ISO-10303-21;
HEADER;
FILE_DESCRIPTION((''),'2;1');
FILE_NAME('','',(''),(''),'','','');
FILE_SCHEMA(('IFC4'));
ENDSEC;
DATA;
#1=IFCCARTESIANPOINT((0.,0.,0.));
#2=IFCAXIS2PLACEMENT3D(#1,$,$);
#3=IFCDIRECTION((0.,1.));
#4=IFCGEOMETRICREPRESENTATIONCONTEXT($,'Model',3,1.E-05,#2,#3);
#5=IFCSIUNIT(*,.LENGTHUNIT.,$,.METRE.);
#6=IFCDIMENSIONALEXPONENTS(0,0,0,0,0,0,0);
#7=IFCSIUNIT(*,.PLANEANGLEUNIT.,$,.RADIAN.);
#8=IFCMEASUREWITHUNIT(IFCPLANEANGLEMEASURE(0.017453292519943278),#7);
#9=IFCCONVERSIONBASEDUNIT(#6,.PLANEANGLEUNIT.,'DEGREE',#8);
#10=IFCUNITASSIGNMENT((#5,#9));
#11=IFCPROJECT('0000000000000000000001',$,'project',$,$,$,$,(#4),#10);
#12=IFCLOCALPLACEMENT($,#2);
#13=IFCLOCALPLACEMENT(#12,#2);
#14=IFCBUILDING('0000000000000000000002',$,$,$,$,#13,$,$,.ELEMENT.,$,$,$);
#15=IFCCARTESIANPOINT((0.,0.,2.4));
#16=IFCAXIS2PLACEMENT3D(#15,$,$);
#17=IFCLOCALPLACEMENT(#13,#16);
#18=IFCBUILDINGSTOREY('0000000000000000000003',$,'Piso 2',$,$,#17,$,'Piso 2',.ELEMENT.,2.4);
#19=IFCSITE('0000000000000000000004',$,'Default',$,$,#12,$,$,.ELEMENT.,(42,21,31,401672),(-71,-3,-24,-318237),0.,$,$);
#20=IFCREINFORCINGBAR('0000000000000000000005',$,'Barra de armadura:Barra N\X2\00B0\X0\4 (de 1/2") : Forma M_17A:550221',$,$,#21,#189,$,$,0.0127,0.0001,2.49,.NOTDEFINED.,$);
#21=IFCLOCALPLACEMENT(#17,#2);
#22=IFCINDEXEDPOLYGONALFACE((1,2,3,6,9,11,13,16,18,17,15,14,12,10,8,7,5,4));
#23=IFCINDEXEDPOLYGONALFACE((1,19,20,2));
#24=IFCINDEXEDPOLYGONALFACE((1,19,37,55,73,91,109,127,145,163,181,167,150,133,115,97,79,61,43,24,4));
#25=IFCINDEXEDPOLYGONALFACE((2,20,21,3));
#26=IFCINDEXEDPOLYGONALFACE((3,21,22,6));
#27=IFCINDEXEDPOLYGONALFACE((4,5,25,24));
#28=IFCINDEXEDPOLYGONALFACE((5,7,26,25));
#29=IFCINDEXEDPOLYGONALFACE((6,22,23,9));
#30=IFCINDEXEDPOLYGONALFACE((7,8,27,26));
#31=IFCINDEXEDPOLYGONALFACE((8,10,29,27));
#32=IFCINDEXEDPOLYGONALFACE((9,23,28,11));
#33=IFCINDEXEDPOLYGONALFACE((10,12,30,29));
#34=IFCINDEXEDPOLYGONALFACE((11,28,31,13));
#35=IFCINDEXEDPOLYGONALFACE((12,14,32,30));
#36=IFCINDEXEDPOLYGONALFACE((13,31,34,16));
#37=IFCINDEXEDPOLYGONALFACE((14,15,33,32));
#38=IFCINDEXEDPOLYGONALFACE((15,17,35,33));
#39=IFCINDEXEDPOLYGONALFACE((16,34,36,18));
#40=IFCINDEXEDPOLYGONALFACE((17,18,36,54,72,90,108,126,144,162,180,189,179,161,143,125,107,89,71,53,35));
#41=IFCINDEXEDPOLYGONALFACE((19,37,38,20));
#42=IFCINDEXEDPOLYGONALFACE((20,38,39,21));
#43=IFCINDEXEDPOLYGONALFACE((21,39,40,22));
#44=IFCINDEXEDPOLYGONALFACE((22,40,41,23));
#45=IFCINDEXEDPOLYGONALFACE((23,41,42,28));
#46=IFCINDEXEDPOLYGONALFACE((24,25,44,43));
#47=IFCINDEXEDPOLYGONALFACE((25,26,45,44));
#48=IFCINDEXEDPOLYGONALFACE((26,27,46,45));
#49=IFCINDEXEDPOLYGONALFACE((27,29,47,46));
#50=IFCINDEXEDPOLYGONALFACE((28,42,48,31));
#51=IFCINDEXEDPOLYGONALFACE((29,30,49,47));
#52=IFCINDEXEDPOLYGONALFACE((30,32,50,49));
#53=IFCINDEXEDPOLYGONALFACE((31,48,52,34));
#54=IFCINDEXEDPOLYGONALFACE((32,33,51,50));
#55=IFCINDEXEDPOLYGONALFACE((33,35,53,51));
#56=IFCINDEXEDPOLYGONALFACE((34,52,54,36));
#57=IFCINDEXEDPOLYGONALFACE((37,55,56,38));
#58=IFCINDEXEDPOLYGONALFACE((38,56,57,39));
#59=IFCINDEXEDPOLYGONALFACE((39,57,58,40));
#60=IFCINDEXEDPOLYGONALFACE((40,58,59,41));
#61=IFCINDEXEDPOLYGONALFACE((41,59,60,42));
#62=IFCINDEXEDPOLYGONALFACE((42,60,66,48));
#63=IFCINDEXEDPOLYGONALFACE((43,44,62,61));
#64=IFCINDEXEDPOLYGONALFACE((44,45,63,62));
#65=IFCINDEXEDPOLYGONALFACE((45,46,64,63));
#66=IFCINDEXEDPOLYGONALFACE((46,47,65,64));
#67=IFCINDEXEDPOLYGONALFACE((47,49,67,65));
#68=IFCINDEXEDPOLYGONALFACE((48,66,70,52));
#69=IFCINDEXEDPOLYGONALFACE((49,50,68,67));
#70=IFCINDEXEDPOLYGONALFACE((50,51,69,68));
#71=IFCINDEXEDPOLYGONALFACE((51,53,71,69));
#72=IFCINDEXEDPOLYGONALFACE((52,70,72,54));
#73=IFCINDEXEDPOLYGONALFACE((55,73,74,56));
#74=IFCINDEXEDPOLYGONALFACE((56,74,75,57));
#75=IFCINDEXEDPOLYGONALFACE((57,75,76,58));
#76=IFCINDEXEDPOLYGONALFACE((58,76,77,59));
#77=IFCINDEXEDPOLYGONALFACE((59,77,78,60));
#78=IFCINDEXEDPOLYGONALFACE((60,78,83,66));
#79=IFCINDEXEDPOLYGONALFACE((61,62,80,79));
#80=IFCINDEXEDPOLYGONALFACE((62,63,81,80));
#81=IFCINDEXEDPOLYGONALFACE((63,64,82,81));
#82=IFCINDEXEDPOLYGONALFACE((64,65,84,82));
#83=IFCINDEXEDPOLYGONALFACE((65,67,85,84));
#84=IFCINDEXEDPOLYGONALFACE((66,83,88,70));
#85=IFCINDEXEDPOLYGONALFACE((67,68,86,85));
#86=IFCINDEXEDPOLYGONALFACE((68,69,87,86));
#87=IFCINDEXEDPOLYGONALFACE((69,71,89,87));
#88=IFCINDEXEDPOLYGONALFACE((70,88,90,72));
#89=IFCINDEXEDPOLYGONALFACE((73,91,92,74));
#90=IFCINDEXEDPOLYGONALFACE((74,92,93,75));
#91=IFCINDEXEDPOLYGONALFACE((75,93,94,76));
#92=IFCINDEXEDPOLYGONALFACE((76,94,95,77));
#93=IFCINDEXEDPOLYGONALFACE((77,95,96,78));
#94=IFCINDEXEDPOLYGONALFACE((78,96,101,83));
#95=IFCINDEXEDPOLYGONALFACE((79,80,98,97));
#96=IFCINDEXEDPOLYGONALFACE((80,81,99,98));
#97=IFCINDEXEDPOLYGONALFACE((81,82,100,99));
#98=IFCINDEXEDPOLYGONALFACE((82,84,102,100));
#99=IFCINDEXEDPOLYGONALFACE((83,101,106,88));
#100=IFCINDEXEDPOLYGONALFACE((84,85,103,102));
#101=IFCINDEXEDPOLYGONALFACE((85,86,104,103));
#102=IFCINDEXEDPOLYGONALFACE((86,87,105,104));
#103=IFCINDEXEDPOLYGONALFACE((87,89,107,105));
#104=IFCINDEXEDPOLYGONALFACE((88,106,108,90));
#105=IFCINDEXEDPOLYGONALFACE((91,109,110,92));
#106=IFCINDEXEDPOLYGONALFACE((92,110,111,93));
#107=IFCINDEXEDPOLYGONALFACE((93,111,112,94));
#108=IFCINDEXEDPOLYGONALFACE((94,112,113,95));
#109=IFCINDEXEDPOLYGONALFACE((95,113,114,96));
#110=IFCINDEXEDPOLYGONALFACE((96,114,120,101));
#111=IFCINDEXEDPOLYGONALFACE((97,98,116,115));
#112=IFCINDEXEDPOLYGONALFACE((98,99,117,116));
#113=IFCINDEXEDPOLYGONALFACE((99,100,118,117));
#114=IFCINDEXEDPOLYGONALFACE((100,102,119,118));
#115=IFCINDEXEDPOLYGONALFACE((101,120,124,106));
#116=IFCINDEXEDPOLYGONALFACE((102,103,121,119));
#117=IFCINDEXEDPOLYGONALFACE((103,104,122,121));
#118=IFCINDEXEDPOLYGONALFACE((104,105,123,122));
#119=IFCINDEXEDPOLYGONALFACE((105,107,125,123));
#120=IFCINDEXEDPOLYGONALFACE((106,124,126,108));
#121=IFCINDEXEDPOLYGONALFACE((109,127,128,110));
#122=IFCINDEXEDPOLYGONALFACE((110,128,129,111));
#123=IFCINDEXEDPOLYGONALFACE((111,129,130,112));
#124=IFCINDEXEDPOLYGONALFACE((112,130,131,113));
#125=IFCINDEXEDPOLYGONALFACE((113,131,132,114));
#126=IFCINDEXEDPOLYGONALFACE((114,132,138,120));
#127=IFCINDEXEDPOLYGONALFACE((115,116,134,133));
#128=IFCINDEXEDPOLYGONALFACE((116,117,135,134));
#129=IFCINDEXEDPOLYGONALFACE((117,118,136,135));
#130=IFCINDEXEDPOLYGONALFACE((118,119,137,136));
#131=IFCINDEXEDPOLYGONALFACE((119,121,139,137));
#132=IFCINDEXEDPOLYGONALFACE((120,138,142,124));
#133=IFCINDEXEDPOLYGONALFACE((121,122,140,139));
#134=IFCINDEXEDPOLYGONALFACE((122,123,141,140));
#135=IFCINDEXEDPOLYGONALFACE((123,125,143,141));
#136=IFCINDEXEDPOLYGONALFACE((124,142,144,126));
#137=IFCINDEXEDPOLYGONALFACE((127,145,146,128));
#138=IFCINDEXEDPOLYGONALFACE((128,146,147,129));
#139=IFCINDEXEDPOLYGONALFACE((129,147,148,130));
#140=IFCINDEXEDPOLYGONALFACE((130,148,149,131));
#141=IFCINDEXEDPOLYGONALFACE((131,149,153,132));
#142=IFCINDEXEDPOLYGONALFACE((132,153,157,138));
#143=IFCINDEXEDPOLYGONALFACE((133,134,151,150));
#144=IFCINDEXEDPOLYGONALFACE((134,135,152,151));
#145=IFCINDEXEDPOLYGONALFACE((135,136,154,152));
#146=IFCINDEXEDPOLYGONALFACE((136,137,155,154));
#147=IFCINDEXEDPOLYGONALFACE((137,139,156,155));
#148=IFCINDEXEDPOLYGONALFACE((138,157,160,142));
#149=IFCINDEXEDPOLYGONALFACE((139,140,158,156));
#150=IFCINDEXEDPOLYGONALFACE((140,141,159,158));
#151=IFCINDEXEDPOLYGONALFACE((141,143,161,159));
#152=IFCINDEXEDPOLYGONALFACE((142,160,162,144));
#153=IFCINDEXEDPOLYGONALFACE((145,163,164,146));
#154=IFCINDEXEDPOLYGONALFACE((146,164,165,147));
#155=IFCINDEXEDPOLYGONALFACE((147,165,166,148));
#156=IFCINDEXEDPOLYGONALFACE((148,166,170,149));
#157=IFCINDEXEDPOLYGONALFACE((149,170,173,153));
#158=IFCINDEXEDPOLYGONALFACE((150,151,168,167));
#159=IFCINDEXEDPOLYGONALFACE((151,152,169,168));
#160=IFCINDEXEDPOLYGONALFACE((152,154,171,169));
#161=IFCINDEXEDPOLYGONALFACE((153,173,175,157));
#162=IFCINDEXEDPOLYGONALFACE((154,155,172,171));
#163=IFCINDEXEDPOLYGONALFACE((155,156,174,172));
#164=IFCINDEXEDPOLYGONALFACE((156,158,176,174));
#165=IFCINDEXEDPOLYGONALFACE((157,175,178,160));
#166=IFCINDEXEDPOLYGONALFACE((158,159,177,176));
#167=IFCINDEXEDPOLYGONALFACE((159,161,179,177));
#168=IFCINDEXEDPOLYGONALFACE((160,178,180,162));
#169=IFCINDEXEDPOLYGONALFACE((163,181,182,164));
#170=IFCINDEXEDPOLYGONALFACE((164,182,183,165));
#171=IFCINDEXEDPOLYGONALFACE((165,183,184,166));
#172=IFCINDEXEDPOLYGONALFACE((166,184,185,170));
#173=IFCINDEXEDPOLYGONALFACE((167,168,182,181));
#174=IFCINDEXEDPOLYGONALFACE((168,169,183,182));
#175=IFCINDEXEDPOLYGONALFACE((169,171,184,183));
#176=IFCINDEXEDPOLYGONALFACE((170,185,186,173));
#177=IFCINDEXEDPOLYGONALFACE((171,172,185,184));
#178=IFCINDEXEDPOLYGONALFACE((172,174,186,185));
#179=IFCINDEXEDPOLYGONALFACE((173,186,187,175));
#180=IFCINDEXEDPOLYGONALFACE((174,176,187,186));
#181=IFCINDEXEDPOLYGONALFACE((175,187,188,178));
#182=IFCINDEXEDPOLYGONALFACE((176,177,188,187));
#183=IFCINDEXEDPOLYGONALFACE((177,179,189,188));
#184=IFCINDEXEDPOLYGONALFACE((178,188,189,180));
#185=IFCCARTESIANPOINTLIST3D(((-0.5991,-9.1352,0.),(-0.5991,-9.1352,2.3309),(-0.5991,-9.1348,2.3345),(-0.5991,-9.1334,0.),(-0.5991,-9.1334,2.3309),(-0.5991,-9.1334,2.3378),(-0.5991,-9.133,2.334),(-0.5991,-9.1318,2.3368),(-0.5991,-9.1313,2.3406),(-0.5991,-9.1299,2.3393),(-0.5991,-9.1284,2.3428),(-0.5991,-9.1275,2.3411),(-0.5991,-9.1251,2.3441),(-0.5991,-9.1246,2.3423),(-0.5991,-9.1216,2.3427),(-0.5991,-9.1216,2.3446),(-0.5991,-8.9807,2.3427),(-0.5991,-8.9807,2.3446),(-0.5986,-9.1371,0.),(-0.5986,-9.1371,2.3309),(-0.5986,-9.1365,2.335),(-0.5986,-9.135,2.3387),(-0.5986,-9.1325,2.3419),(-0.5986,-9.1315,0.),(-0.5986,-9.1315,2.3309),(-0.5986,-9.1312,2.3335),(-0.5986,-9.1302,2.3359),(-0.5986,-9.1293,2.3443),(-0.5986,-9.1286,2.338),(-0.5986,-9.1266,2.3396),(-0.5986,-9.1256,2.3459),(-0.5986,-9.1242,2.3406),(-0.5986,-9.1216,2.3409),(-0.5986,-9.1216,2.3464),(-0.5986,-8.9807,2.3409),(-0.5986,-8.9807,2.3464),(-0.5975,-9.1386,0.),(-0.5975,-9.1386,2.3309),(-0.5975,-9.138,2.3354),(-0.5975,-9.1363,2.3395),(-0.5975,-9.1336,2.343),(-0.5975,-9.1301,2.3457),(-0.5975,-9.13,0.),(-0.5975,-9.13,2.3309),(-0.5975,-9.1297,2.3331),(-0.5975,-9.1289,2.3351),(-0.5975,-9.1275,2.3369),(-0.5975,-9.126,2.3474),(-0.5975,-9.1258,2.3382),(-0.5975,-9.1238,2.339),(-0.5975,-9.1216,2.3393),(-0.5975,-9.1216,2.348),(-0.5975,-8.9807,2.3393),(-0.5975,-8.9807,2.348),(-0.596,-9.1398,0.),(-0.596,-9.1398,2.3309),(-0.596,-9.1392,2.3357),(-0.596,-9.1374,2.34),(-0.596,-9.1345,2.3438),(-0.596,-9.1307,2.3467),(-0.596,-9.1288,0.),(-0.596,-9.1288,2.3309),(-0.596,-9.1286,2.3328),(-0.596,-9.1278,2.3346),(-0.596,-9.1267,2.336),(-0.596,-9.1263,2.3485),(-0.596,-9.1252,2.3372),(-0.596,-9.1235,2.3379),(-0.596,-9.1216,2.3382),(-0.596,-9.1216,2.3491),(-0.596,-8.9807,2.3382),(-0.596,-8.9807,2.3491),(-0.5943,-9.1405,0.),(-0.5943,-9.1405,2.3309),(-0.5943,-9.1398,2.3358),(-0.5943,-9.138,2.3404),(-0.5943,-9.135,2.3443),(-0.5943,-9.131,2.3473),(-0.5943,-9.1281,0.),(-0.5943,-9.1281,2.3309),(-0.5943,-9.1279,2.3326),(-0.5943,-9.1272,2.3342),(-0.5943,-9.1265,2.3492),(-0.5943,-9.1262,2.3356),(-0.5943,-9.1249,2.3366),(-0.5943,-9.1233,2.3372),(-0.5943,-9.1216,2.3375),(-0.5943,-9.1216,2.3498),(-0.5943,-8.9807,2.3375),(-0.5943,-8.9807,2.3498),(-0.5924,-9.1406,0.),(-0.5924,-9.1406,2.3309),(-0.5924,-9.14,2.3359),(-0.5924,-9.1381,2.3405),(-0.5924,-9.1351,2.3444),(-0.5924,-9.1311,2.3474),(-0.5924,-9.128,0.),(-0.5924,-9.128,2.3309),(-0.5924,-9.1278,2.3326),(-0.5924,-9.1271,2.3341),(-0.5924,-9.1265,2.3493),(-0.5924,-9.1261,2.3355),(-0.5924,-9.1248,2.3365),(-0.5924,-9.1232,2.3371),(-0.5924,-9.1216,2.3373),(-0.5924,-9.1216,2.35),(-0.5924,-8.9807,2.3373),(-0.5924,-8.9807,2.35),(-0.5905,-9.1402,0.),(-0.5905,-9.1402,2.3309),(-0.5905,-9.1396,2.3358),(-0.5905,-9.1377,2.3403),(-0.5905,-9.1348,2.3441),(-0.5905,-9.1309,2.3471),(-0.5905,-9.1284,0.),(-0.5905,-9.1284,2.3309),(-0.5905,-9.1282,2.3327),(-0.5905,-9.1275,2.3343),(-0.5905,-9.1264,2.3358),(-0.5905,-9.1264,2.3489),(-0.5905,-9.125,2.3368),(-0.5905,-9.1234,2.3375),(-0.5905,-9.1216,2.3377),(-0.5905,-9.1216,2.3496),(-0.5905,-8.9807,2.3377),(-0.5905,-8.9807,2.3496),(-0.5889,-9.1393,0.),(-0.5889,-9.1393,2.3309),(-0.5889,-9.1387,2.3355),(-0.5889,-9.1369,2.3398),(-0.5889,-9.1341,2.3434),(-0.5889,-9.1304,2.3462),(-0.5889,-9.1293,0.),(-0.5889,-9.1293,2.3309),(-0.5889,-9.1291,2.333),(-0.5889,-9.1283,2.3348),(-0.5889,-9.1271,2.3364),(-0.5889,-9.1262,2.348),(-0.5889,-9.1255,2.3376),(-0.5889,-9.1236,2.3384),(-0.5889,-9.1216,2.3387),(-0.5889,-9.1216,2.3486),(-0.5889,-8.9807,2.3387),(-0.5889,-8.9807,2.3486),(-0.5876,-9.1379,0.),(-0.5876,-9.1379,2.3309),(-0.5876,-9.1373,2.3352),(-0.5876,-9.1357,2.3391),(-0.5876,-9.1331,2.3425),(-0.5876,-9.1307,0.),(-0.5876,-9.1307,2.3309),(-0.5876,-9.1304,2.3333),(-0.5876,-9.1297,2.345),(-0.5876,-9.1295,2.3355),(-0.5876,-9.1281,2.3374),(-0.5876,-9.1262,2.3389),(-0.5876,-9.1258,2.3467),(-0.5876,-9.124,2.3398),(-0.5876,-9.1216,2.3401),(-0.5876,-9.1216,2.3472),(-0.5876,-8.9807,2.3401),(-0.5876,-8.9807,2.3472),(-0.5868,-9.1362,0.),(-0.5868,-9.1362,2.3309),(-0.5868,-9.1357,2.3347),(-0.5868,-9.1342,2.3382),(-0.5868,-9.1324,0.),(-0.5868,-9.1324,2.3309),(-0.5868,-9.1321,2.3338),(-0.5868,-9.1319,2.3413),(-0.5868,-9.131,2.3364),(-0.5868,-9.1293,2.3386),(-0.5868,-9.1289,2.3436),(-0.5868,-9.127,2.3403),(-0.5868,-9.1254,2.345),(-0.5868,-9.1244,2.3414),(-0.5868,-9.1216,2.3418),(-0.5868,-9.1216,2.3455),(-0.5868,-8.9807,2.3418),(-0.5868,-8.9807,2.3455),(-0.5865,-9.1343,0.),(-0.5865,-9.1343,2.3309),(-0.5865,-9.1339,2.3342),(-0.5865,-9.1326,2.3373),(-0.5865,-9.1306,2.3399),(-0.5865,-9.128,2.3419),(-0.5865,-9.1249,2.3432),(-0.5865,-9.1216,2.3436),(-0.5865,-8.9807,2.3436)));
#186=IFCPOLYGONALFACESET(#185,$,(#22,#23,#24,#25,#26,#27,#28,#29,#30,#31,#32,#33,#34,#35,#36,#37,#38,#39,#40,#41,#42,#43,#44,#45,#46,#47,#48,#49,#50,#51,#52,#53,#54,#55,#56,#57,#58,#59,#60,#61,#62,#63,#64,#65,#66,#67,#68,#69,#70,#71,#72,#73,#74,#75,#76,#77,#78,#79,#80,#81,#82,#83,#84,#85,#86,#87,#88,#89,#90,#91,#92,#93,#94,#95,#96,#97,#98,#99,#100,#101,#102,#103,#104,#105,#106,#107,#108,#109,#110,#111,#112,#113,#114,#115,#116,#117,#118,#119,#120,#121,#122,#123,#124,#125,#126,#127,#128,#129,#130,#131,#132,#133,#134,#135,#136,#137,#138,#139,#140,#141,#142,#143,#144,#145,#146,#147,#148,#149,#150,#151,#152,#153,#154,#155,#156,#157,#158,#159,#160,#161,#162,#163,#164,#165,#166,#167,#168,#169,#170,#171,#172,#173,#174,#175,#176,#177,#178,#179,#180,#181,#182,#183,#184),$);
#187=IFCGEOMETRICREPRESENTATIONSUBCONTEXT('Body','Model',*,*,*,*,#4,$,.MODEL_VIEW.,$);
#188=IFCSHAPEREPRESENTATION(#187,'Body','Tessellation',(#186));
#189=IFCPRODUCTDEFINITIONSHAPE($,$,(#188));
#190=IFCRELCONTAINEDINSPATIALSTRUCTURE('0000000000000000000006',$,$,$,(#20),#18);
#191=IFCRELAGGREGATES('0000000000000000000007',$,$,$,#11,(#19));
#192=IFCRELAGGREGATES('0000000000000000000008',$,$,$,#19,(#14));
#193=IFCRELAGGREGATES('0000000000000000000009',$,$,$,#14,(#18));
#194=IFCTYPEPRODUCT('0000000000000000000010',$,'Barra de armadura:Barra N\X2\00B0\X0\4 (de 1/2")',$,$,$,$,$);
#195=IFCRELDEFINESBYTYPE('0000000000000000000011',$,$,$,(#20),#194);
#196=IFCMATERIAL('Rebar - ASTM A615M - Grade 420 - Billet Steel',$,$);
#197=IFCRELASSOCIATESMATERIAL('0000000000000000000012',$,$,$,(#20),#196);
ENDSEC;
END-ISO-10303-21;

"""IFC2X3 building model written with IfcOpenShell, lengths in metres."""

from ifc_helpers import new_model, entity, si_unit, converted_unit, direction, frame, origin, place, context, subcontext, project, spatial, material, type_object, element, save


model = new_model("IFC2X3")

# Units and contexts
model_context = context("Model", 3, precision=1e-05, world=origin(), true_north=direction((0.0, 1.0)))
body_context = subcontext(model_context, "Body", "Model", "MODEL_VIEW")
ifc_project = project(units=[si_unit("LENGTHUNIT", "METRE"), converted_unit("PLANEANGLEUNIT", "DEGREE", entity("IfcPlaneAngleMeasure", 0.017453292519943278), si_unit("PLANEANGLEUNIT", "RADIAN"), dimensions=[0, 0, 0, 0, 0, 0, 0])], contexts=[model_context])

# Site, building, storey
site_placement = place(None, origin())
site = spatial("IfcSite", under=ifc_project, at=site_placement, Name="Default", CompositionType="ELEMENT", RefLatitude=(42, 21, 31, 401672), RefLongitude=(-71, -3, -24, -318237), RefElevation=0.0)
building_placement = place(site_placement, origin())
building = spatial("IfcBuilding", under=site, at=building_placement, CompositionType="ELEMENT")
storey_placement = place(building_placement, frame((0.0, 0.0, 2.4)))
storey = spatial("IfcBuildingStorey", under=building, at=storey_placement, Name="Piso 2", LongName="Piso 2", CompositionType="ELEMENT", Elevation=2.4)

# Reinforcing bar
ifc_material_1 = material(Name="Rebar - ASTM A615M - Grade 420 - Billet Steel")
type_product = type_object("IfcTypeProduct", Name="Barra de armadura:Barra N°4 (de 1/2\")")
reinforcing_bar_1_placement = place(storey_placement, origin())
element("IfcReinforcingBar", 1, at=reinforcing_bar_1_placement, inside=storey, type_object=type_product, material=ifc_material_1, Name="Barra de armadura:Barra N°4 (de 1/2\") : Forma M_17A:550221", BarLength=2.49, BarRole="NOTDEFINED", CrossSectionArea=0.0001, NominalDiameter=0.0127, context=body_context, shape_type="AdvancedSweptSolid", body=[
    entity("IfcSweptDiskSolid", entity("IfcCompositeCurve", [entity("IfcCompositeCurveSegment", "CONTINUOUS", True, entity("IfcPolyline", [entity("IfcCartesianPoint", [-0.5929, -9.1343, 0.0]), entity("IfcCartesianPoint", [-0.5929, -9.1343, 2.3309])])), entity("IfcCompositeCurveSegment", "CONTINUOUS", True, entity("IfcTrimmedCurve", entity("IfcCircle", entity("IfcAxis2Placement3D", entity("IfcCartesianPoint", [-0.5929, -9.1216, 2.3309]), entity("IfcDirection", [-1.0, 0.0, 0.0]), entity("IfcDirection", [0.0, 0.0, 1.0])), 0.0127), [entity("IfcParameterValue", 270.0)], [entity("IfcParameterValue", 360.0)], True, "PARAMETER")), entity("IfcCompositeCurveSegment", "CONTINUOUS", True, entity("IfcPolyline", [entity("IfcCartesianPoint", [-0.5929, -9.1216, 2.3436]), entity("IfcCartesianPoint", [-0.5929, -8.9807, 2.3436])]))], False), 0.0063, None, 0.0, 92.0),
])

save(model, "model.ifc")
